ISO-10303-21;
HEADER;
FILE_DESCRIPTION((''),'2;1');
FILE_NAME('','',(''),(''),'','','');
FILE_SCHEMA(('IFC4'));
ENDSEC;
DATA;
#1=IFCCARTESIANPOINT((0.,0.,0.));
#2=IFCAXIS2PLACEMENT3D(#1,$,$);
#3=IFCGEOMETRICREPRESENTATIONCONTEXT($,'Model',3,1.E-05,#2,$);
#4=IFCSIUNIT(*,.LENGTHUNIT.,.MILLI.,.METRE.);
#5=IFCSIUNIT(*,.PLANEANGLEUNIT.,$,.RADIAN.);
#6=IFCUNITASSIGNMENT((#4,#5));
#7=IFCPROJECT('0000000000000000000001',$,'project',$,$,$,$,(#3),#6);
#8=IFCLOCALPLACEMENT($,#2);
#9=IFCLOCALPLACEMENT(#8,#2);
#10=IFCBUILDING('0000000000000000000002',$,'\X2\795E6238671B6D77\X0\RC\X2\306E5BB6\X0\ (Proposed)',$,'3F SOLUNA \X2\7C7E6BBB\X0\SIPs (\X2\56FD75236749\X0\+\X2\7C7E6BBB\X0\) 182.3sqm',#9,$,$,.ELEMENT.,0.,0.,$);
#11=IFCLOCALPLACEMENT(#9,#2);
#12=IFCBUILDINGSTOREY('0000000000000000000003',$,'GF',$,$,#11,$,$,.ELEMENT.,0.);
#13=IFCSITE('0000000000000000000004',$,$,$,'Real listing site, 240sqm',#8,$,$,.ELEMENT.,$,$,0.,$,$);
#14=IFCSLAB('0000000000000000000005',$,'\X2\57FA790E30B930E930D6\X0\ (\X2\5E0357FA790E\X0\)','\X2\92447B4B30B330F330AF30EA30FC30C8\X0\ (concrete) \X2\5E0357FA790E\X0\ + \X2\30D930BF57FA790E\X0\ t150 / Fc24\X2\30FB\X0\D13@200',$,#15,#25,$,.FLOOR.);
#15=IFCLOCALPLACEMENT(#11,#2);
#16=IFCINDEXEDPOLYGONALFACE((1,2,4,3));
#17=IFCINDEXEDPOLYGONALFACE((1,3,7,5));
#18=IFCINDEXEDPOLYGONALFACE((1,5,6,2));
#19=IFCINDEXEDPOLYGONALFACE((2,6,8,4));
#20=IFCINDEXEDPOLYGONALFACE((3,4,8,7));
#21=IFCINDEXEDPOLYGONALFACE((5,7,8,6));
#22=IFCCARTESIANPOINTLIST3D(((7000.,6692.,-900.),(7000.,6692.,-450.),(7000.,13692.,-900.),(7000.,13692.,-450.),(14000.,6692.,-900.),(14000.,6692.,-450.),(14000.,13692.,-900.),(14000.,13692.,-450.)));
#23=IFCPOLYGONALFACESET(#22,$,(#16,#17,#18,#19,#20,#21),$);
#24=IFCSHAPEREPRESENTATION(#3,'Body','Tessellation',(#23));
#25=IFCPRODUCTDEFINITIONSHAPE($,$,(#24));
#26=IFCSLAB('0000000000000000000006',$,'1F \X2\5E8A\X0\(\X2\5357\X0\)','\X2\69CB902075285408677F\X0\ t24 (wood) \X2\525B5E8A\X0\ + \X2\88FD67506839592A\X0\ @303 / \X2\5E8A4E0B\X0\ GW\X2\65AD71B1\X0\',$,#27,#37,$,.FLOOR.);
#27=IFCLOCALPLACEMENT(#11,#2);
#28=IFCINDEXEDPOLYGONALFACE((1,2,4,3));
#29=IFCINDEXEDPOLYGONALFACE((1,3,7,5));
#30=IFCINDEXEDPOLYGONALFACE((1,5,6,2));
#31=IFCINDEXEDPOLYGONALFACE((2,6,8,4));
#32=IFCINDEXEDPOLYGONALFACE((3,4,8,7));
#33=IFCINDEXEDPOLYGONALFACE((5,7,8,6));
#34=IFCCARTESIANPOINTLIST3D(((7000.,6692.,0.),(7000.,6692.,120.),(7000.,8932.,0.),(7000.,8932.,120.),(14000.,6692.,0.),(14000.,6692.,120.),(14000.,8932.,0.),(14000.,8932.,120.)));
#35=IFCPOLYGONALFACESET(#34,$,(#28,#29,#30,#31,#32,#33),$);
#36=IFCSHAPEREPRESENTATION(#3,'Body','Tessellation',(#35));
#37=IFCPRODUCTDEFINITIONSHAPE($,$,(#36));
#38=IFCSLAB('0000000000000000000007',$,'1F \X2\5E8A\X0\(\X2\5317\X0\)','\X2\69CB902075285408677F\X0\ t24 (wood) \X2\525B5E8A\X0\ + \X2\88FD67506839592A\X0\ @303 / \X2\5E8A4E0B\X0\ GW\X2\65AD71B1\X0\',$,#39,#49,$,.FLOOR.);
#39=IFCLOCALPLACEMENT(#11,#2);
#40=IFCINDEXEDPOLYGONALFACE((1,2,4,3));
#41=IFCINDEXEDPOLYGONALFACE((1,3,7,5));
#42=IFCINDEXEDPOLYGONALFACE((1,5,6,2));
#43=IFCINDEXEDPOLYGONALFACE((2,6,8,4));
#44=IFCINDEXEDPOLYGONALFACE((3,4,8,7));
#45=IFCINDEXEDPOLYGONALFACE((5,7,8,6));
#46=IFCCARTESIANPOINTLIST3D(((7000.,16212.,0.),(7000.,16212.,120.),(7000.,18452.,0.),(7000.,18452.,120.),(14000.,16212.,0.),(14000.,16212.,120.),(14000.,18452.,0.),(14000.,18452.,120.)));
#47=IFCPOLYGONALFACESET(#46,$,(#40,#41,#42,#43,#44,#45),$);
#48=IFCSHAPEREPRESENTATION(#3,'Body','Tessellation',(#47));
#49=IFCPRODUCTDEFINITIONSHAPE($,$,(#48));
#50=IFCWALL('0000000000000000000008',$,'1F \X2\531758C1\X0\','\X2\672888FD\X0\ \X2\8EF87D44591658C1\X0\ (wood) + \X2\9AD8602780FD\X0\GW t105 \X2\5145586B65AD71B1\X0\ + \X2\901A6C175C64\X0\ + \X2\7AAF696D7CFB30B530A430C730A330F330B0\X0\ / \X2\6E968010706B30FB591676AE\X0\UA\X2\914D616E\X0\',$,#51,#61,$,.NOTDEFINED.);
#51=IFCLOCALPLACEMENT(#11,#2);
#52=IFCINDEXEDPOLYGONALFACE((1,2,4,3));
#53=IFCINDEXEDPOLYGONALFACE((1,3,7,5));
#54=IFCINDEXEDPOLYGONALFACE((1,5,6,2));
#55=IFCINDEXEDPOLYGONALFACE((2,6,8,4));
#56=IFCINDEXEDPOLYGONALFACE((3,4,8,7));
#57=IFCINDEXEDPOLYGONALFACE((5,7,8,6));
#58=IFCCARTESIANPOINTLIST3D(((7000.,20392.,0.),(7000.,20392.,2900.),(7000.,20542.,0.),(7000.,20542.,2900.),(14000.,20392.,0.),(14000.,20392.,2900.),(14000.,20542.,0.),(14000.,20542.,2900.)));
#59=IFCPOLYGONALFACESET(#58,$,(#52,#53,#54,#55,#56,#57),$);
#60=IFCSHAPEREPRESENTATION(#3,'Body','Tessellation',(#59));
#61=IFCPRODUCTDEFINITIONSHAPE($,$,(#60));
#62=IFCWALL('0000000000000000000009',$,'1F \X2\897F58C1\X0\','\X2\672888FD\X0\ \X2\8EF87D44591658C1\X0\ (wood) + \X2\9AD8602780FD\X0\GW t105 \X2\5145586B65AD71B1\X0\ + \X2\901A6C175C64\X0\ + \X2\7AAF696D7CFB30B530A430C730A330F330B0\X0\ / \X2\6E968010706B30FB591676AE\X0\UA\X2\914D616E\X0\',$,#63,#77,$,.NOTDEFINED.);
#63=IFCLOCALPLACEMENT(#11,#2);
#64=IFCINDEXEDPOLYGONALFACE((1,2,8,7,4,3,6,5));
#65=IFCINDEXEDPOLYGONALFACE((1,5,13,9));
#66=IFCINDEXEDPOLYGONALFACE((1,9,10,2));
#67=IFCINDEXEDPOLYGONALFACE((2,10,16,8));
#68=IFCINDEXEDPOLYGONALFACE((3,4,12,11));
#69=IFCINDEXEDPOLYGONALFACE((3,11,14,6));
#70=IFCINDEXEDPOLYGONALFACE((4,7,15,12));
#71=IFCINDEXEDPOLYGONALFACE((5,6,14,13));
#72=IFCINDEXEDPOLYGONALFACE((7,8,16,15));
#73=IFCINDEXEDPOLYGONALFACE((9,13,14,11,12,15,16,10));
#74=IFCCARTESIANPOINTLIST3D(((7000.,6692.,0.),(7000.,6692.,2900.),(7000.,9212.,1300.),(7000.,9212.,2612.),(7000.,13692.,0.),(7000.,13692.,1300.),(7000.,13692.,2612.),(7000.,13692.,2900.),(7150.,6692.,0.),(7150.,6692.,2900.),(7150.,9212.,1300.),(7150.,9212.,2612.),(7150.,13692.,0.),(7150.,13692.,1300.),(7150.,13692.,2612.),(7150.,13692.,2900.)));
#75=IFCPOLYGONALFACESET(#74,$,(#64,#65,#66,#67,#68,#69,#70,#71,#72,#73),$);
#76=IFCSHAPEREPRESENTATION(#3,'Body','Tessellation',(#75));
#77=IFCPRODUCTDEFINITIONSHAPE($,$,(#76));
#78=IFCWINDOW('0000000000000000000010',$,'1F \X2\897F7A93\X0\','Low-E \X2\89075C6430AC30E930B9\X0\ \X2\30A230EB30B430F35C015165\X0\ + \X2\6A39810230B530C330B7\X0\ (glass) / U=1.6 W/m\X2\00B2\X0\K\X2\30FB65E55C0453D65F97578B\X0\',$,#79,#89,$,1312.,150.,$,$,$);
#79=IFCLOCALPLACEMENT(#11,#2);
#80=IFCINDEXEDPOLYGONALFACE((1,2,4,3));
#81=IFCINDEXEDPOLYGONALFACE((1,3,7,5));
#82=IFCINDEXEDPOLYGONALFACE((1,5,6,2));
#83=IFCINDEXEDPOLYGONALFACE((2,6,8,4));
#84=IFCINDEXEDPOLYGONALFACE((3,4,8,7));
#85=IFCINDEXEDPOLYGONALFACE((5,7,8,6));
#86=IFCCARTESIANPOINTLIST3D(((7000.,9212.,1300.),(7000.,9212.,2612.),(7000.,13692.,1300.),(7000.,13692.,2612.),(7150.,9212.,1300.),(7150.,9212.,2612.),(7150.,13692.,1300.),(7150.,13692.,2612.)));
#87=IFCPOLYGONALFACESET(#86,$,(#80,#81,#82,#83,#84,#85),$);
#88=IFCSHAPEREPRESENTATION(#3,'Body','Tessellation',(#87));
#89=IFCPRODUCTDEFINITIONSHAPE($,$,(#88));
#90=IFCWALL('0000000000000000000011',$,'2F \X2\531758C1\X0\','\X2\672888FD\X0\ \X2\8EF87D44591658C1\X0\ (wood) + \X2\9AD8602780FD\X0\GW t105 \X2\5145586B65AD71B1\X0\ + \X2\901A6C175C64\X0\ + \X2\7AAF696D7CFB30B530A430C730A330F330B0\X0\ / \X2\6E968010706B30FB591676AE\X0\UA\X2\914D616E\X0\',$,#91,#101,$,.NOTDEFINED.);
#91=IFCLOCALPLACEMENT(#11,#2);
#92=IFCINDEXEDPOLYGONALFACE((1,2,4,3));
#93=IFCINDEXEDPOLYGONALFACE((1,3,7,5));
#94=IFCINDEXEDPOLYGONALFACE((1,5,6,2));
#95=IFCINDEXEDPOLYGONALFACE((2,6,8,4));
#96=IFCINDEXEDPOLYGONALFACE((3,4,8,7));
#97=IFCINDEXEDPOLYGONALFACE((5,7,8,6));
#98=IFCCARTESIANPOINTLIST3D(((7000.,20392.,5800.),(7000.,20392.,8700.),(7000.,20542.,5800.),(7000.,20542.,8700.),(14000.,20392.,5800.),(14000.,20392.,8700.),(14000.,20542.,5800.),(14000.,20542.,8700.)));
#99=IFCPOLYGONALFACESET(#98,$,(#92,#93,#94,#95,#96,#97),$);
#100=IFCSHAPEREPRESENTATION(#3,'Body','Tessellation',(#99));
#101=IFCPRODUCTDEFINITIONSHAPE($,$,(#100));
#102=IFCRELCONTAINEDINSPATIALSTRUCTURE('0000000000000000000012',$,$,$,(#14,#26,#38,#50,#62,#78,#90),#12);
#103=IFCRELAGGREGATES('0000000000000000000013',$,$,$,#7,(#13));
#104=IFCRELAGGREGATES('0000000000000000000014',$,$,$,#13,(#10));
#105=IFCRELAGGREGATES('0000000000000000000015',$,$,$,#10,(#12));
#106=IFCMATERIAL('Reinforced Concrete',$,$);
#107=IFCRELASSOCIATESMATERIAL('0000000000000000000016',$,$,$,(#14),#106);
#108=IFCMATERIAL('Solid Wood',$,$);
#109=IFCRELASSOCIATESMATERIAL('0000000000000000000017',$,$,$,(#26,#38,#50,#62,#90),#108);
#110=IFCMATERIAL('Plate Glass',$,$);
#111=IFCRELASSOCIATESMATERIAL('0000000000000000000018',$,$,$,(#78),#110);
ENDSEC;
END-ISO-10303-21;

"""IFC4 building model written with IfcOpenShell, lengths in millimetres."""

from ifc_helpers import new_model, si_unit, frame, frame_2d, origin, place, context, project, spatial, rectangle, extrude, material, element, fill, save


model = new_model("IFC4")

# Units and contexts
model_context = context("Model", 3, precision=1e-05, world=origin())
ifc_project = project(units=[si_unit("LENGTHUNIT", "METRE", prefix="MILLI"), si_unit("PLANEANGLEUNIT", "RADIAN")], contexts=[model_context])

# Site, building, storey
site_placement = place(None, origin())
site = spatial("IfcSite", under=ifc_project, at=site_placement, ObjectType="Real listing site, 240sqm", CompositionType="ELEMENT", RefElevation=0.0)
building_placement = place(site_placement, origin())
building = spatial("IfcBuilding", under=site, at=building_placement, Name="神戸望海RCの家 (Proposed)", ObjectType="3F SOLUNA 籾殻SIPs (国産杉+籾殻) 182.3sqm", CompositionType="ELEMENT", ElevationOfRefHeight=0.0, ElevationOfTerrain=0.0)
storey_placement = place(building_placement, origin())
storey = spatial("IfcBuildingStorey", under=building, at=storey_placement, Name="GF", CompositionType="ELEMENT", Elevation=0.0)

# Slabs
ifc_material_1 = material(Name="Reinforced Concrete")
slab_1_placement = place(storey_placement, frame((3500.0, 3346.0, -450.0)))
element("IfcSlab", 1, at=slab_1_placement, inside=storey, material=ifc_material_1, Name="基礎スラブ (布基礎)", Description="鉄筋コンクリート (concrete) 布基礎 + ベタ基礎 t150 / Fc24・D13@200", PredefinedType="FLOOR", context=model_context, shape_type="SweptSolid", body=[
    extrude(rectangle(XDim=7000.0, YDim=7000.0, at=frame_2d((3500.0, 3500.0))), frame((3500.0, 3346.0, -450.0)), (0.0, 0.0, 1.0), 450.0),
])
ifc_material_2 = material(Name="Solid Wood")
slab_2_placement = place(storey_placement, frame((3500.0, 3346.0, 0.0)))
element("IfcSlab", 2, at=slab_2_placement, inside=storey, material=ifc_material_2, Name="1F 床(南)", Description="構造用合板 t24 (wood) 剛床 + 製材根太 @303 / 床下 GW断熱", PredefinedType="FLOOR", context=model_context, shape_type="SweptSolid", body=[
    extrude(rectangle(XDim=7000.0, YDim=2240.0, at=frame_2d((3500.0, 1120.0))), frame((3500.0, 3346.0, 0.0)), (0.0, 0.0, 1.0), 120.0),
])
slab_3_placement = place(storey_placement, frame((3500.0, 8106.0, 0.0)))
element("IfcSlab", 3, at=slab_3_placement, inside=storey, material=ifc_material_2, Name="1F 床(北)", Description="構造用合板 t24 (wood) 剛床 + 製材根太 @303 / 床下 GW断熱", PredefinedType="FLOOR", context=model_context, shape_type="SweptSolid", body=[
    extrude(rectangle(XDim=7000.0, YDim=2240.0, at=frame_2d((3500.0, 1120.0))), frame((3500.0, 8106.0, 0.0)), (0.0, 0.0, 1.0), 120.0),
])

# Shared definitions
ifc_material_3 = material(Name="Plate Glass")

# Wall
wall_1_placement = place(storey_placement, frame((3500.0, 10196.0, 0.0)))
element("IfcWall", 4, at=wall_1_placement, inside=storey, material=ifc_material_2, Name="1F 北壁", Description="木製 軸組外壁 (wood) + 高性能GW t105 充填断熱 + 通気層 + 窯業系サイディング / 準耐火・外皮UA配慮", PredefinedType="NOTDEFINED", context=model_context, shape_type="SweptSolid", body=[
    extrude(rectangle(XDim=7000.0, YDim=150.0, at=frame_2d((3500.0, 75.0))), frame((3500.0, 10196.0, 0.0)), (0.0, 0.0, 1.0), 2900.0),
])

# Wall, opening, window
wall_2_placement = place(storey_placement, frame((3500.0, 3346.0, 0.0)))
wall_2 = element("IfcWall", 5, at=wall_2_placement, inside=storey, material=ifc_material_2, Name="1F 西壁", Description="木製 軸組外壁 (wood) + 高性能GW t105 充填断熱 + 通気層 + 窯業系サイディング / 準耐火・外皮UA配慮", PredefinedType="NOTDEFINED", context=model_context, shape_type="SweptSolid", body=[
    extrude(rectangle(XDim=150.0, YDim=7000.0, at=frame_2d((75.0, 3500.0))), frame((3500.0, 3346.0, 0.0)), (0.0, 0.0, 1.0), 2900.0),
])
opening_1_placement = place(storey_placement, frame((3500.0, 4606.0, 650.0)))
opening_1 = element("IfcOpeningElement", 6, at=opening_1_placement, cuts=wall_2, PredefinedType="NOTDEFINED", context=model_context, shape_type="SweptSolid", body=[
    extrude(rectangle(XDim=150.0, YDim=4480.0, at=frame_2d((75.0, 2240.0))), frame((3500.0, 4606.0, 650.0)), (0.0, 0.0, 1.0), 1312.0),
])
window_1_placement = place(storey_placement, frame((3500.0, 4606.0, 650.0)))
window_1 = element("IfcWindow", 7, at=window_1_placement, inside=storey, material=ifc_material_3, Name="1F 西窓", Description="Low-E 複層ガラス アルゴン封入 + 樹脂サッシ (glass) / U=1.6 W/m²K・日射取得型", OverallHeight=1312.0, OverallWidth=150.0, context=model_context, shape_type="SweptSolid", body=[
    extrude(rectangle(XDim=150.0, YDim=4480.0, at=frame_2d((75.0, 2240.0))), frame((3500.0, 4606.0, 650.0)), (0.0, 0.0, 1.0), 1312.0),
])
fill(opening_1, window_1)

# Wall
wall_3_placement = place(storey_placement, frame((3500.0, 10196.0, 2900.0)))
element("IfcWall", 8, at=wall_3_placement, inside=storey, material=ifc_material_2, Name="2F 北壁", Description="木製 軸組外壁 (wood) + 高性能GW t105 充填断熱 + 通気層 + 窯業系サイディング / 準耐火・外皮UA配慮", PredefinedType="NOTDEFINED", context=model_context, shape_type="SweptSolid", body=[
    extrude(rectangle(XDim=7000.0, YDim=150.0, at=frame_2d((3500.0, 75.0))), frame((3500.0, 10196.0, 2900.0)), (0.0, 0.0, 1.0), 2900.0),
])

save(model, "model.ifc")
